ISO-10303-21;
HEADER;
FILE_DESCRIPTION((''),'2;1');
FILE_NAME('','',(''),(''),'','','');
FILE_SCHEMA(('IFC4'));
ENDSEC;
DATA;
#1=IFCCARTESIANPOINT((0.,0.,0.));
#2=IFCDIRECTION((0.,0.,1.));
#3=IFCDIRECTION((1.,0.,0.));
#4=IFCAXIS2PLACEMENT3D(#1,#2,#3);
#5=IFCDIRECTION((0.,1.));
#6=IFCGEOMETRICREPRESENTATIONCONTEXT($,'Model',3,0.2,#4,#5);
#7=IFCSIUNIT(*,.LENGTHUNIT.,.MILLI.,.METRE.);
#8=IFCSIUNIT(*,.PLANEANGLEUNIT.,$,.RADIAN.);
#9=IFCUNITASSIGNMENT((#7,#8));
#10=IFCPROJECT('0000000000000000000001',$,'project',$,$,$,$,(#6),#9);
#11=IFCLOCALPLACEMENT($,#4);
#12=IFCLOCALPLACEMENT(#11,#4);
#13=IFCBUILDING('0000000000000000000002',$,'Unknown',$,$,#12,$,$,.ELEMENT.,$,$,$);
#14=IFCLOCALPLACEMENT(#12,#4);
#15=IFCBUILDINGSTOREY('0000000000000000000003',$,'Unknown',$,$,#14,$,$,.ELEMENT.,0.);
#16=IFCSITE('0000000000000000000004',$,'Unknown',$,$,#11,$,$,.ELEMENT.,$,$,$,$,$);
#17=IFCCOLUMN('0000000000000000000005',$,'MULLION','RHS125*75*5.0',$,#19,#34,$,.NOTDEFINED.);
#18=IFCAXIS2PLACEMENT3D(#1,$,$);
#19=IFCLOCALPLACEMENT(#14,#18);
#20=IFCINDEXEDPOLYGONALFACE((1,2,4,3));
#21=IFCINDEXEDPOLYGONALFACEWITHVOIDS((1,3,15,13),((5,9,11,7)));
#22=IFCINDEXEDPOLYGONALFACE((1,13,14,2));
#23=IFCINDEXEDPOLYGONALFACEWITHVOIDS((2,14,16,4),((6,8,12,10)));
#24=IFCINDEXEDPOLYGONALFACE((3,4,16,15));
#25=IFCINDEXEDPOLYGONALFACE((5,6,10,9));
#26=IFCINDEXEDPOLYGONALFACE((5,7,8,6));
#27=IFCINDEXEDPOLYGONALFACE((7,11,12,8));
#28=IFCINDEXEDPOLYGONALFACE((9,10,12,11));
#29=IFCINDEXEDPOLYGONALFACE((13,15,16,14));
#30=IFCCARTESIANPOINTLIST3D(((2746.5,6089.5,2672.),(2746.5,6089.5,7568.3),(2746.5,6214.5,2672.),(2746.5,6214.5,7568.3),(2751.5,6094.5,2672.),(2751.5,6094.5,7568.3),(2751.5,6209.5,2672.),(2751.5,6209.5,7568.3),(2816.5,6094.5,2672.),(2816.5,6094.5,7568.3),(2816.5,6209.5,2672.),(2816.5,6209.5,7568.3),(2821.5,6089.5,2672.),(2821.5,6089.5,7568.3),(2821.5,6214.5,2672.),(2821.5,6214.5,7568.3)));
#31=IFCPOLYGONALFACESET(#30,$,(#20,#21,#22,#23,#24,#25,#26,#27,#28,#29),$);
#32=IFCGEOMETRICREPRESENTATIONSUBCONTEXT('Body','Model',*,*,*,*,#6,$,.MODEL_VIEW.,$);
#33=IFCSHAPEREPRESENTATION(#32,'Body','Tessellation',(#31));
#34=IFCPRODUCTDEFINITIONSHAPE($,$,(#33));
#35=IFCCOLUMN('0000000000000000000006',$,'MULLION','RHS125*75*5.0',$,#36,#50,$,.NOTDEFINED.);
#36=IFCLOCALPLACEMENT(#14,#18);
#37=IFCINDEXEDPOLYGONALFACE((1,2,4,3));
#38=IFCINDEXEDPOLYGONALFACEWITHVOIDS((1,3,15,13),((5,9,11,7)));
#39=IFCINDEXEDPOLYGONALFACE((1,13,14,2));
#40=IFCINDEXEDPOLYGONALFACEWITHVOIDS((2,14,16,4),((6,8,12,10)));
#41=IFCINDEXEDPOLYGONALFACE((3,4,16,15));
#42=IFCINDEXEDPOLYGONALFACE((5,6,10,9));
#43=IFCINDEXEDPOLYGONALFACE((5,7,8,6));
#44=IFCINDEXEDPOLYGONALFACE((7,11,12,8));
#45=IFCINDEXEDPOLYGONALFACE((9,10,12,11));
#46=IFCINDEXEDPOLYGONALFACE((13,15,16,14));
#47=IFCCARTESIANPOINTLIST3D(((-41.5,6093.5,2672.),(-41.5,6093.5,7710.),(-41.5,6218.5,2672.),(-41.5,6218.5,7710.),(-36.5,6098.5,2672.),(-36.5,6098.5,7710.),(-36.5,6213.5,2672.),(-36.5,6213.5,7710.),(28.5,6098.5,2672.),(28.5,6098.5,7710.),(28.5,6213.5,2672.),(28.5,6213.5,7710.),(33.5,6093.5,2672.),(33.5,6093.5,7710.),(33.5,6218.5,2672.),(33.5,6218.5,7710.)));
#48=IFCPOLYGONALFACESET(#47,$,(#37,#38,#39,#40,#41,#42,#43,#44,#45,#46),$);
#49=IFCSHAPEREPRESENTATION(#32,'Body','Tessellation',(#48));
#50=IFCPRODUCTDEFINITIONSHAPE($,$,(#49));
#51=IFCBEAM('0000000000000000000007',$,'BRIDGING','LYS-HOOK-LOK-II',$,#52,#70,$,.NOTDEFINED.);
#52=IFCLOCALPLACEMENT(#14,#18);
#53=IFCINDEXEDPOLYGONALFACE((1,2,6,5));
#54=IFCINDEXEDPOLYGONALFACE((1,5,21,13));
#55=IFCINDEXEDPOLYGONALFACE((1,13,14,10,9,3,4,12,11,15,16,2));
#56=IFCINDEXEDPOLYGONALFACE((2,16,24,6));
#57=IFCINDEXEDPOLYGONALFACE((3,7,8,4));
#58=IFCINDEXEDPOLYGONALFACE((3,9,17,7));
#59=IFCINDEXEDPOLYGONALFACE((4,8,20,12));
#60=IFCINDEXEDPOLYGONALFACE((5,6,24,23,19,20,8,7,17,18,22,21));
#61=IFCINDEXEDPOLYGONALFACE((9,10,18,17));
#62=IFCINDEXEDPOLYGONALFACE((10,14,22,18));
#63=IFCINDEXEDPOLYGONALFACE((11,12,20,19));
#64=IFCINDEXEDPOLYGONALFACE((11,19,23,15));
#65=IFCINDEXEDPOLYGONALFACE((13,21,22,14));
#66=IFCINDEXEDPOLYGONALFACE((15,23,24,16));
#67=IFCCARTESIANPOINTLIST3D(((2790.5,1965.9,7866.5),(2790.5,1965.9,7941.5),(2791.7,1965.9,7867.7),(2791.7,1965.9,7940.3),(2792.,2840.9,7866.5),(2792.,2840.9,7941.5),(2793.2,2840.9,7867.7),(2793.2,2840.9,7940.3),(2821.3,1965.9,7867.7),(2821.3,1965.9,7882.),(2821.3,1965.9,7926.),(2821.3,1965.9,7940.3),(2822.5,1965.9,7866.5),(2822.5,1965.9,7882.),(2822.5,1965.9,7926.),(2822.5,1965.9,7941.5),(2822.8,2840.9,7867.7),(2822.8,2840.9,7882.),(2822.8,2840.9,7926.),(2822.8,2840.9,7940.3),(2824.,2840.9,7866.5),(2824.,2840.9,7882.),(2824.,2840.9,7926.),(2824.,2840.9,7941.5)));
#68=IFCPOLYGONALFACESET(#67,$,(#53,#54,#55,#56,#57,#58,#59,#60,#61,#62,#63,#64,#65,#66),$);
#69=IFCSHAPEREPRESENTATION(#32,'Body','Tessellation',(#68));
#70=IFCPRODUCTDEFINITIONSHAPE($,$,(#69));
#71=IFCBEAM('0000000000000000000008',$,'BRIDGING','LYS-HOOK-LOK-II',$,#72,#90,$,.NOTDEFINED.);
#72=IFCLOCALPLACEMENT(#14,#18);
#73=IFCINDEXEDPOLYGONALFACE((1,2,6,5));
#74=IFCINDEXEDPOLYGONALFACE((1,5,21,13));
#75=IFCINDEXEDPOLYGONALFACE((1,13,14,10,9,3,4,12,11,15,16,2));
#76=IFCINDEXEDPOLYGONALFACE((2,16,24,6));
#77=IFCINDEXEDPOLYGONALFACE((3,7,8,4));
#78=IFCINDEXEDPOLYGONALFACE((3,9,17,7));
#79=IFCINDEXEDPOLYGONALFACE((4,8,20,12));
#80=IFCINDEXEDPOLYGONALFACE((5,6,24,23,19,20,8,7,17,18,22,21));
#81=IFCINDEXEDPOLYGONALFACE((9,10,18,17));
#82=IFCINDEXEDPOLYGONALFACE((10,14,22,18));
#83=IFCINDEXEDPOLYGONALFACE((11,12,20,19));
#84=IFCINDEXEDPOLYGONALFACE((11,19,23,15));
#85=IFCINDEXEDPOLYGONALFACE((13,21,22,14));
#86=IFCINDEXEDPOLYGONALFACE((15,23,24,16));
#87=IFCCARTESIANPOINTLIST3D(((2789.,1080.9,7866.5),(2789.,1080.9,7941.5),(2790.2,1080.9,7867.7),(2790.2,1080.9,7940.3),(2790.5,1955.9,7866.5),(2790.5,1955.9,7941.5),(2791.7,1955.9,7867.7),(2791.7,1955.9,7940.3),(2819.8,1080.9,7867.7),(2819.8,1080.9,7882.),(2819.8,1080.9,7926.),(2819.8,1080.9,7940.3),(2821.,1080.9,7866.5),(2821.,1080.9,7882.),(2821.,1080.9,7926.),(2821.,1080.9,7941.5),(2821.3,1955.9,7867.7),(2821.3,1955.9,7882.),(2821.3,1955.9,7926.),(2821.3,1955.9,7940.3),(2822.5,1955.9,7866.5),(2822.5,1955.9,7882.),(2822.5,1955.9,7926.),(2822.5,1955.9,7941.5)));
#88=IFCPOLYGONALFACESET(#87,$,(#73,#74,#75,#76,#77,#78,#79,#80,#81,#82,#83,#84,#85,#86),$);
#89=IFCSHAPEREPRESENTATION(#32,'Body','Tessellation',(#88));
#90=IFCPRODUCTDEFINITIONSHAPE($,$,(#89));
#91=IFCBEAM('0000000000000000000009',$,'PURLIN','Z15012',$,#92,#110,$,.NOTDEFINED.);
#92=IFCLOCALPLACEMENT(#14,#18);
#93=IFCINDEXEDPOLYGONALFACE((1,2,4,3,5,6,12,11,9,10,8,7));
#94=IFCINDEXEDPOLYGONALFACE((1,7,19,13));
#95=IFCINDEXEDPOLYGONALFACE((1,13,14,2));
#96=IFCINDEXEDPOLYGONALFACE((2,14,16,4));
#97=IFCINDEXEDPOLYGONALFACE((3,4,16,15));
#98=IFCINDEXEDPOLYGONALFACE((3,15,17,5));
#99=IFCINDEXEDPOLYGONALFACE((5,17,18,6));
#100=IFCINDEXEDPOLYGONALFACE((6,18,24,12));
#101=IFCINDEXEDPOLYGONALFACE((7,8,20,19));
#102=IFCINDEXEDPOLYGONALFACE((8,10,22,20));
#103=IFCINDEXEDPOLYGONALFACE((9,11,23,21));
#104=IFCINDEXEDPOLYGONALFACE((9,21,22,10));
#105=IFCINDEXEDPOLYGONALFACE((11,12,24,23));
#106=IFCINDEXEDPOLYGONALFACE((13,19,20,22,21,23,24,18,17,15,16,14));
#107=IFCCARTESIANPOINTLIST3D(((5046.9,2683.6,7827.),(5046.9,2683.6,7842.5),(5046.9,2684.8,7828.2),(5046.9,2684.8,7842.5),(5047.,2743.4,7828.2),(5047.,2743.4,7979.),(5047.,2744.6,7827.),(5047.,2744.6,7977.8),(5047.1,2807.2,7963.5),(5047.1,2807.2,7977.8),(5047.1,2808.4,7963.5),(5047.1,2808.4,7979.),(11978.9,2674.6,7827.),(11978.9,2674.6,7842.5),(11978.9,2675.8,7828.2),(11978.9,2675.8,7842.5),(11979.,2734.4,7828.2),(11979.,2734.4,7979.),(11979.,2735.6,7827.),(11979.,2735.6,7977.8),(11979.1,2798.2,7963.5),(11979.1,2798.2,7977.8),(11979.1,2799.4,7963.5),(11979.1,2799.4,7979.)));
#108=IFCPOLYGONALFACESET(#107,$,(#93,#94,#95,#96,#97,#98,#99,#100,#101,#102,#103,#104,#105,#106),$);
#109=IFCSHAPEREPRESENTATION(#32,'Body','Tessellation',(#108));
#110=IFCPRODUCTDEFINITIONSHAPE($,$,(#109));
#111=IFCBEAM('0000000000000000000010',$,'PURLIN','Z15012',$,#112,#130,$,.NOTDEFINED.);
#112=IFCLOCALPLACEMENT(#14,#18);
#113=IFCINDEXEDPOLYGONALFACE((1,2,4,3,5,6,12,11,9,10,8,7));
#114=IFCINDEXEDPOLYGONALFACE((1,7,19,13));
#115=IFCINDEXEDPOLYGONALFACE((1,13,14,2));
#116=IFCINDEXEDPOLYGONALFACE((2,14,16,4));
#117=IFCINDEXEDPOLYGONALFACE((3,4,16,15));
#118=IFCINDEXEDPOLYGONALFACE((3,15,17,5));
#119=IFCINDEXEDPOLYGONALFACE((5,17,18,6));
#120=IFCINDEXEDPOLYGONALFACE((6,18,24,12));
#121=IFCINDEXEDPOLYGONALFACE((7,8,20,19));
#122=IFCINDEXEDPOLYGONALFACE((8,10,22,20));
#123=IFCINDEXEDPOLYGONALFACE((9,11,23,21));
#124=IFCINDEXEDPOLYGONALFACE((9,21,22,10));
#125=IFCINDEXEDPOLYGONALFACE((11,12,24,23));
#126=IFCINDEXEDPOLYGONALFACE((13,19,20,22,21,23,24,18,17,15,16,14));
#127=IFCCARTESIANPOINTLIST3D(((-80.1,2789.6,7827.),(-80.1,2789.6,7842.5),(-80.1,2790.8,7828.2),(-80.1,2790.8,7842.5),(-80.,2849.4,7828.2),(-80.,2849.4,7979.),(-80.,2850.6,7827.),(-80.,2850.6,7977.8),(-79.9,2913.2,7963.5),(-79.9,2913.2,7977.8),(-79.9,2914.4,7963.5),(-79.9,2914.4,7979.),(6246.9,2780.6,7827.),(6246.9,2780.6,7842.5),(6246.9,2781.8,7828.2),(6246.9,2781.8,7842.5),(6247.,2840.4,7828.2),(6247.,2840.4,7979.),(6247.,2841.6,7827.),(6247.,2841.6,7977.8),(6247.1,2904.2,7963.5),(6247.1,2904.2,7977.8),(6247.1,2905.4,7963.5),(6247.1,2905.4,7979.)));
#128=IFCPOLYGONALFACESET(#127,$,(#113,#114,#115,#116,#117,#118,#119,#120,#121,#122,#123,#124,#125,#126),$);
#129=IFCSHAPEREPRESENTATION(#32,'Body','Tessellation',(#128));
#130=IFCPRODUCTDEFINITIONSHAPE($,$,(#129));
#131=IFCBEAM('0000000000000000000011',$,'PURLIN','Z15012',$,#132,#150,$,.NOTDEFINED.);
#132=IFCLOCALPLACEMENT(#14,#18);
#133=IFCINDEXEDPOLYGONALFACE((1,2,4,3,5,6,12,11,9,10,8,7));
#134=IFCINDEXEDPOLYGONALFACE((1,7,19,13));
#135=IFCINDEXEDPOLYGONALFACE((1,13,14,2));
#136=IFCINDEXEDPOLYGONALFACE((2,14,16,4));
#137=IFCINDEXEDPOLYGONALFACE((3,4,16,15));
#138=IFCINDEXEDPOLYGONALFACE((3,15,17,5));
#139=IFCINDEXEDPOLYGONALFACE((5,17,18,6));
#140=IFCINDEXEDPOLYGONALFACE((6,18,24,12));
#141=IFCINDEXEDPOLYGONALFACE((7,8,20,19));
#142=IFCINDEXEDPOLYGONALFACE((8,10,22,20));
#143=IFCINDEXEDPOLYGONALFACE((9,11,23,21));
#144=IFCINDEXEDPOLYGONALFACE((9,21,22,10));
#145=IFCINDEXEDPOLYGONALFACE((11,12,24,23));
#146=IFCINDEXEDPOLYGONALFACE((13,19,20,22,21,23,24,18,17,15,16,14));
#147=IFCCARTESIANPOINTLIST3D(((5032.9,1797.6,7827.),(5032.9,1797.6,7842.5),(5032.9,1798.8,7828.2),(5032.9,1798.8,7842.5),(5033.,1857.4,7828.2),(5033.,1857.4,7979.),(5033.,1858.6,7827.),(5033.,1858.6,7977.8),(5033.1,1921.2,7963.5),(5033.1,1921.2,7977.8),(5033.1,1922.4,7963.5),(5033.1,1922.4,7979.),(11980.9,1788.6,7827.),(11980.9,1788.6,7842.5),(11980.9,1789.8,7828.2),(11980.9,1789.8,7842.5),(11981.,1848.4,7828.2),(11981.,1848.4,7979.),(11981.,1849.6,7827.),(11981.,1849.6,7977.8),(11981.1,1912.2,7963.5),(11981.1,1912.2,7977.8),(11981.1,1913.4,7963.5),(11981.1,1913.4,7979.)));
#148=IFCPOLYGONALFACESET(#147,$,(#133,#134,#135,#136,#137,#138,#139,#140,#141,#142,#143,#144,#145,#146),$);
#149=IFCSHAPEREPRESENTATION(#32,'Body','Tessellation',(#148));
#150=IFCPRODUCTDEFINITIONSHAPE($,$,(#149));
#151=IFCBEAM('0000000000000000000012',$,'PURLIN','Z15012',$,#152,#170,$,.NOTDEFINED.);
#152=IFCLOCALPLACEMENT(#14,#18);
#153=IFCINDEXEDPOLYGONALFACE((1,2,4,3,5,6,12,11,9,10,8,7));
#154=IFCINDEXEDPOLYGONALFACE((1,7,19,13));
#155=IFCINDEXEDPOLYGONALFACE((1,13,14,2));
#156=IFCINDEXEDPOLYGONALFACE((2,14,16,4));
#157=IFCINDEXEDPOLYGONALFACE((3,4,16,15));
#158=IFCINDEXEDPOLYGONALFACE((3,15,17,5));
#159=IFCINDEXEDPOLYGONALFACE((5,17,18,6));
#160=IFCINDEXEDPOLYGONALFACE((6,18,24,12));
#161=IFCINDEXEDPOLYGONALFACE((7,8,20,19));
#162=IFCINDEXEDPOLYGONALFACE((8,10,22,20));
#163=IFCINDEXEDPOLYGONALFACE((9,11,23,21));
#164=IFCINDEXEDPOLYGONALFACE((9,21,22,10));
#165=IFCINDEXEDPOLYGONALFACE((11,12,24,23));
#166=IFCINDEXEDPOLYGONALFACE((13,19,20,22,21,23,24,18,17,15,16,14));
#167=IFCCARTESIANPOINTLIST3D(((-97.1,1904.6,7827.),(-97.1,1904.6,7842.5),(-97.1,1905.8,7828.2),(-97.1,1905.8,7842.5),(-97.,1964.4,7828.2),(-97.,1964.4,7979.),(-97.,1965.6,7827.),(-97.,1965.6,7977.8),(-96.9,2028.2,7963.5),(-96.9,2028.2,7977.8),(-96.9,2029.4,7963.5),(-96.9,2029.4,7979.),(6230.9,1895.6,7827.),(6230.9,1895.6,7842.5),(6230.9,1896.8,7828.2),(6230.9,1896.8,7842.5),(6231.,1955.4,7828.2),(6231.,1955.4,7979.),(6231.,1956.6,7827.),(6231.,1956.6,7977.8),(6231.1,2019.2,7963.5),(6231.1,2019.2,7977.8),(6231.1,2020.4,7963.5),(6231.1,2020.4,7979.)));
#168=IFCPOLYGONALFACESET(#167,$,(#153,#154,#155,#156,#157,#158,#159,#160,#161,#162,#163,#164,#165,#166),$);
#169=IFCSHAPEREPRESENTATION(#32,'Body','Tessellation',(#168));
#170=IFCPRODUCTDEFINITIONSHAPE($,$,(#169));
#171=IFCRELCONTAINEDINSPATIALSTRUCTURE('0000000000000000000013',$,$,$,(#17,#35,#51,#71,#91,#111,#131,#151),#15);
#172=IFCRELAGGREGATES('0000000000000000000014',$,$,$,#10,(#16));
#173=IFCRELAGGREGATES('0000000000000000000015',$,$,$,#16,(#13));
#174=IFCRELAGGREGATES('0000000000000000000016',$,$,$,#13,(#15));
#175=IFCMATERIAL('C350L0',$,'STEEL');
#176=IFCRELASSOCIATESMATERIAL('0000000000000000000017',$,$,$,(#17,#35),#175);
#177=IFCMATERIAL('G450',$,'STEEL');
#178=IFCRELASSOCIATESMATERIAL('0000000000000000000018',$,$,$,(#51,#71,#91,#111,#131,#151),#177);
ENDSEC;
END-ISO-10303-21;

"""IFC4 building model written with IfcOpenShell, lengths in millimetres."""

from ifc_helpers import new_model, si_unit, direction, frame, origin_with_axes, place, context, subcontext, project, spatial, line, indexed_curve, outline, extrude, material, element, save


model = new_model("IFC4")

# Units and contexts
model_context = context("Model", 3, precision=0.2, world=origin_with_axes(), true_north=direction((0.0, 1.0)))
body_context = subcontext(model_context, "Body", "Model", "MODEL_VIEW")
ifc_project = project(units=[si_unit("LENGTHUNIT", "METRE", prefix="MILLI"), si_unit("PLANEANGLEUNIT", "RADIAN")], contexts=[model_context])

# Site, building, storey
site_placement = place(None, origin_with_axes())
site = spatial("IfcSite", under=ifc_project, at=site_placement, Name="Unknown", CompositionType="ELEMENT")
building_placement = place(site_placement, origin_with_axes())
building = spatial("IfcBuilding", under=site, at=building_placement, Name="Unknown", CompositionType="ELEMENT")
storey_placement = place(building_placement, origin_with_axes())
storey = spatial("IfcBuildingStorey", under=building, at=storey_placement, Name="Unknown", CompositionType="ELEMENT", Elevation=0.0)

# Columns
ifc_material_1 = material(Name="C350L0", Category="STEEL")
column_1_placement = place(storey_placement, frame((2784.0, 6152.0, 2672.0), z_axis=(1.0, 0.0, 0.0), x_axis=(0.0, 0.0, 1.0)))
element("IfcColumn", 1, at=column_1_placement, inside=storey, material=ifc_material_1, Name="MULLION", Description="RHS125*75*5.0", PredefinedType="NOTDEFINED", context=body_context, shape_type="SolidModel", body=[
    extrude(outline(indexed_curve([(-37.5, -62.5), (37.5, -62.5), (37.5, 62.5), (-37.5, 62.5)], segments=[line(1, 2, 3, 4, 1)]), holes=[indexed_curve([(-32.5, -57.5), (-32.5, 57.5), (32.5, 57.5), (32.5, -57.5)], segments=[line(1, 2, 3, 4, 1)])]), frame((0.0, 0.0, 0.0), z_axis=(-1.0, 0.0, 0.0), x_axis=(0.0, 0.0, 1.0)), (0.0, 0.0, -1.0), 4896.3),
])
column_2_placement = place(storey_placement, frame((-4.0, 6156.0, 2672.0), z_axis=(1.0, 0.0, 0.0), x_axis=(0.0, 0.0, 1.0)))
element("IfcColumn", 2, at=column_2_placement, inside=storey, material=ifc_material_1, Name="MULLION", Description="RHS125*75*5.0", PredefinedType="NOTDEFINED", context=body_context, shape_type="SolidModel", body=[
    extrude(outline(indexed_curve([(-37.5, -62.5), (37.5, -62.5), (37.5, 62.5), (-37.5, 62.5)], segments=[line(1, 2, 3, 4, 1)]), holes=[indexed_curve([(-32.5, -57.5), (-32.5, 57.5), (32.5, 57.5), (32.5, -57.5)], segments=[line(1, 2, 3, 4, 1)])]), frame((0.0, 0.0, 0.0), z_axis=(-1.0, 0.0, 0.0), x_axis=(0.0, 0.0, 1.0)), (0.0, 0.0, -1.0), 5038.0),
])

# Beams
ifc_material_2 = material(Name="G450", Category="STEEL")
for number, where, z_axis, x_axis, name in (
    (3, (2806.5, 1965.9, 7904.0), (0.999999, -0.001714, 0.0), (0.001714, 0.999999, 0.0), "BRIDGING"),
    (4, (2805.0, 1080.9, 7904.0), (0.999999, -0.001714, 0.0), (0.001714, 0.999999, 0.0), "BRIDGING"),
):
    element("IfcBeam", number, at=place(storey_placement, frame(where, z_axis=z_axis, x_axis=x_axis)), inside=storey, material=ifc_material_2, Name=name, Description="LYS-HOOK-LOK-II", PredefinedType="NOTDEFINED", context=body_context, shape_type="SolidModel", body=[
        extrude(outline(indexed_curve([(16.0, -37.5), (16.0, -22.0), (14.8, -22.0), (14.8, -36.3), (-14.8, -36.3), (-14.8, 36.3), (14.8, 36.3), (14.8, 22.0), (16.0, 22.0), (16.0, 37.5), (-16.0, 37.5), (-16.0, -37.5)], segments=[line(1, 2, 3, 4, 5, 6, 7, 8, 9, 10, 11, 12, 1)])), frame((0.0, 0.0, 0.0), z_axis=(-1.0, 0.0, 0.0), x_axis=(0.0, 0.0, 1.0)), (0.0, 0.0, -1.0), 875.0),
    ])
beam_1_placement = place(storey_placement, frame((5047.0, 2744.0, 7903.0), z_axis=(-0.001298, -0.999999, 0.0), x_axis=(0.999999, -0.001298, 0.0)))
element("IfcBeam", 5, at=beam_1_placement, inside=storey, material=ifc_material_2, Name="PURLIN", Description="Z15012", PredefinedType="NOTDEFINED", context=body_context, shape_type="SolidModel", body=[
    extrude(outline(indexed_curve([(60.4, -76.0), (60.4, -60.5), (59.2, -60.5), (59.2, -74.8), (0.6, -74.8), (0.6, 76.0), (-64.4, 76.0), (-64.4, 60.5), (-63.2, 60.5), (-63.2, 74.8), (-0.6, 74.8), (-0.6, -76.0)], segments=[line(1, 2, 3, 4, 5, 6, 7, 8, 9, 10, 11, 12, 1)])), frame((0.0, 0.0, 0.0), z_axis=(-1.0, 0.0, 0.0), x_axis=(0.0, 0.0, 1.0)), (0.0, 0.0, -1.0), 6932.0),
])
beam_2_placement = place(storey_placement, frame((-80.0, 2850.0, 7903.0), z_axis=(-0.001422, -0.999999, 0.0), x_axis=(0.999999, -0.001422, 0.0)))
element("IfcBeam", 6, at=beam_2_placement, inside=storey, material=ifc_material_2, Name="PURLIN", Description="Z15012", PredefinedType="NOTDEFINED", context=body_context, shape_type="SolidModel", body=[
    extrude(outline(indexed_curve([(60.4, -76.0), (60.4, -60.5), (59.2, -60.5), (59.2, -74.8), (0.6, -74.8), (0.6, 76.0), (-64.4, 76.0), (-64.4, 60.5), (-63.2, 60.5), (-63.2, 74.8), (-0.6, 74.8), (-0.6, -76.0)], segments=[line(1, 2, 3, 4, 5, 6, 7, 8, 9, 10, 11, 12, 1)])), frame((0.0, 0.0, 0.0), z_axis=(-1.0, 0.0, 0.0), x_axis=(0.0, 0.0, 1.0)), (0.0, 0.0, -1.0), 6327.0),
])
beam_3_placement = place(storey_placement, frame((5033.0, 1858.0, 7903.0), z_axis=(-0.001295, -0.999999, 0.0), x_axis=(0.999999, -0.001295, 0.0)))
element("IfcBeam", 7, at=beam_3_placement, inside=storey, material=ifc_material_2, Name="PURLIN", Description="Z15012", PredefinedType="NOTDEFINED", context=body_context, shape_type="SolidModel", body=[
    extrude(outline(indexed_curve([(60.4, -76.0), (60.4, -60.5), (59.2, -60.5), (59.2, -74.8), (0.6, -74.8), (0.6, 76.0), (-64.4, 76.0), (-64.4, 60.5), (-63.2, 60.5), (-63.2, 74.8), (-0.6, 74.8), (-0.6, -76.0)], segments=[line(1, 2, 3, 4, 5, 6, 7, 8, 9, 10, 11, 12, 1)])), frame((0.0, 0.0, 0.0), z_axis=(-1.0, 0.0, 0.0), x_axis=(0.0, 0.0, 1.0)), (0.0, 0.0, -1.0), 6948.0),
])
beam_4_placement = place(storey_placement, frame((-97.0, 1965.0, 7903.0), z_axis=(-0.001422, -0.999999, 0.0), x_axis=(0.999999, -0.001422, 0.0)))
element("IfcBeam", 8, at=beam_4_placement, inside=storey, material=ifc_material_2, Name="PURLIN", Description="Z15012", PredefinedType="NOTDEFINED", context=body_context, shape_type="SolidModel", body=[
    extrude(outline(indexed_curve([(60.4, -76.0), (60.4, -60.5), (59.2, -60.5), (59.2, -74.8), (0.6, -74.8), (0.6, 76.0), (-64.4, 76.0), (-64.4, 60.5), (-63.2, 60.5), (-63.2, 74.8), (-0.6, 74.8), (-0.6, -76.0)], segments=[line(1, 2, 3, 4, 5, 6, 7, 8, 9, 10, 11, 12, 1)])), frame((0.0, 0.0, 0.0), z_axis=(-1.0, 0.0, 0.0), x_axis=(0.0, 0.0, 1.0)), (0.0, 0.0, -1.0), 6328.0),
])

save(model, "model.ifc")
